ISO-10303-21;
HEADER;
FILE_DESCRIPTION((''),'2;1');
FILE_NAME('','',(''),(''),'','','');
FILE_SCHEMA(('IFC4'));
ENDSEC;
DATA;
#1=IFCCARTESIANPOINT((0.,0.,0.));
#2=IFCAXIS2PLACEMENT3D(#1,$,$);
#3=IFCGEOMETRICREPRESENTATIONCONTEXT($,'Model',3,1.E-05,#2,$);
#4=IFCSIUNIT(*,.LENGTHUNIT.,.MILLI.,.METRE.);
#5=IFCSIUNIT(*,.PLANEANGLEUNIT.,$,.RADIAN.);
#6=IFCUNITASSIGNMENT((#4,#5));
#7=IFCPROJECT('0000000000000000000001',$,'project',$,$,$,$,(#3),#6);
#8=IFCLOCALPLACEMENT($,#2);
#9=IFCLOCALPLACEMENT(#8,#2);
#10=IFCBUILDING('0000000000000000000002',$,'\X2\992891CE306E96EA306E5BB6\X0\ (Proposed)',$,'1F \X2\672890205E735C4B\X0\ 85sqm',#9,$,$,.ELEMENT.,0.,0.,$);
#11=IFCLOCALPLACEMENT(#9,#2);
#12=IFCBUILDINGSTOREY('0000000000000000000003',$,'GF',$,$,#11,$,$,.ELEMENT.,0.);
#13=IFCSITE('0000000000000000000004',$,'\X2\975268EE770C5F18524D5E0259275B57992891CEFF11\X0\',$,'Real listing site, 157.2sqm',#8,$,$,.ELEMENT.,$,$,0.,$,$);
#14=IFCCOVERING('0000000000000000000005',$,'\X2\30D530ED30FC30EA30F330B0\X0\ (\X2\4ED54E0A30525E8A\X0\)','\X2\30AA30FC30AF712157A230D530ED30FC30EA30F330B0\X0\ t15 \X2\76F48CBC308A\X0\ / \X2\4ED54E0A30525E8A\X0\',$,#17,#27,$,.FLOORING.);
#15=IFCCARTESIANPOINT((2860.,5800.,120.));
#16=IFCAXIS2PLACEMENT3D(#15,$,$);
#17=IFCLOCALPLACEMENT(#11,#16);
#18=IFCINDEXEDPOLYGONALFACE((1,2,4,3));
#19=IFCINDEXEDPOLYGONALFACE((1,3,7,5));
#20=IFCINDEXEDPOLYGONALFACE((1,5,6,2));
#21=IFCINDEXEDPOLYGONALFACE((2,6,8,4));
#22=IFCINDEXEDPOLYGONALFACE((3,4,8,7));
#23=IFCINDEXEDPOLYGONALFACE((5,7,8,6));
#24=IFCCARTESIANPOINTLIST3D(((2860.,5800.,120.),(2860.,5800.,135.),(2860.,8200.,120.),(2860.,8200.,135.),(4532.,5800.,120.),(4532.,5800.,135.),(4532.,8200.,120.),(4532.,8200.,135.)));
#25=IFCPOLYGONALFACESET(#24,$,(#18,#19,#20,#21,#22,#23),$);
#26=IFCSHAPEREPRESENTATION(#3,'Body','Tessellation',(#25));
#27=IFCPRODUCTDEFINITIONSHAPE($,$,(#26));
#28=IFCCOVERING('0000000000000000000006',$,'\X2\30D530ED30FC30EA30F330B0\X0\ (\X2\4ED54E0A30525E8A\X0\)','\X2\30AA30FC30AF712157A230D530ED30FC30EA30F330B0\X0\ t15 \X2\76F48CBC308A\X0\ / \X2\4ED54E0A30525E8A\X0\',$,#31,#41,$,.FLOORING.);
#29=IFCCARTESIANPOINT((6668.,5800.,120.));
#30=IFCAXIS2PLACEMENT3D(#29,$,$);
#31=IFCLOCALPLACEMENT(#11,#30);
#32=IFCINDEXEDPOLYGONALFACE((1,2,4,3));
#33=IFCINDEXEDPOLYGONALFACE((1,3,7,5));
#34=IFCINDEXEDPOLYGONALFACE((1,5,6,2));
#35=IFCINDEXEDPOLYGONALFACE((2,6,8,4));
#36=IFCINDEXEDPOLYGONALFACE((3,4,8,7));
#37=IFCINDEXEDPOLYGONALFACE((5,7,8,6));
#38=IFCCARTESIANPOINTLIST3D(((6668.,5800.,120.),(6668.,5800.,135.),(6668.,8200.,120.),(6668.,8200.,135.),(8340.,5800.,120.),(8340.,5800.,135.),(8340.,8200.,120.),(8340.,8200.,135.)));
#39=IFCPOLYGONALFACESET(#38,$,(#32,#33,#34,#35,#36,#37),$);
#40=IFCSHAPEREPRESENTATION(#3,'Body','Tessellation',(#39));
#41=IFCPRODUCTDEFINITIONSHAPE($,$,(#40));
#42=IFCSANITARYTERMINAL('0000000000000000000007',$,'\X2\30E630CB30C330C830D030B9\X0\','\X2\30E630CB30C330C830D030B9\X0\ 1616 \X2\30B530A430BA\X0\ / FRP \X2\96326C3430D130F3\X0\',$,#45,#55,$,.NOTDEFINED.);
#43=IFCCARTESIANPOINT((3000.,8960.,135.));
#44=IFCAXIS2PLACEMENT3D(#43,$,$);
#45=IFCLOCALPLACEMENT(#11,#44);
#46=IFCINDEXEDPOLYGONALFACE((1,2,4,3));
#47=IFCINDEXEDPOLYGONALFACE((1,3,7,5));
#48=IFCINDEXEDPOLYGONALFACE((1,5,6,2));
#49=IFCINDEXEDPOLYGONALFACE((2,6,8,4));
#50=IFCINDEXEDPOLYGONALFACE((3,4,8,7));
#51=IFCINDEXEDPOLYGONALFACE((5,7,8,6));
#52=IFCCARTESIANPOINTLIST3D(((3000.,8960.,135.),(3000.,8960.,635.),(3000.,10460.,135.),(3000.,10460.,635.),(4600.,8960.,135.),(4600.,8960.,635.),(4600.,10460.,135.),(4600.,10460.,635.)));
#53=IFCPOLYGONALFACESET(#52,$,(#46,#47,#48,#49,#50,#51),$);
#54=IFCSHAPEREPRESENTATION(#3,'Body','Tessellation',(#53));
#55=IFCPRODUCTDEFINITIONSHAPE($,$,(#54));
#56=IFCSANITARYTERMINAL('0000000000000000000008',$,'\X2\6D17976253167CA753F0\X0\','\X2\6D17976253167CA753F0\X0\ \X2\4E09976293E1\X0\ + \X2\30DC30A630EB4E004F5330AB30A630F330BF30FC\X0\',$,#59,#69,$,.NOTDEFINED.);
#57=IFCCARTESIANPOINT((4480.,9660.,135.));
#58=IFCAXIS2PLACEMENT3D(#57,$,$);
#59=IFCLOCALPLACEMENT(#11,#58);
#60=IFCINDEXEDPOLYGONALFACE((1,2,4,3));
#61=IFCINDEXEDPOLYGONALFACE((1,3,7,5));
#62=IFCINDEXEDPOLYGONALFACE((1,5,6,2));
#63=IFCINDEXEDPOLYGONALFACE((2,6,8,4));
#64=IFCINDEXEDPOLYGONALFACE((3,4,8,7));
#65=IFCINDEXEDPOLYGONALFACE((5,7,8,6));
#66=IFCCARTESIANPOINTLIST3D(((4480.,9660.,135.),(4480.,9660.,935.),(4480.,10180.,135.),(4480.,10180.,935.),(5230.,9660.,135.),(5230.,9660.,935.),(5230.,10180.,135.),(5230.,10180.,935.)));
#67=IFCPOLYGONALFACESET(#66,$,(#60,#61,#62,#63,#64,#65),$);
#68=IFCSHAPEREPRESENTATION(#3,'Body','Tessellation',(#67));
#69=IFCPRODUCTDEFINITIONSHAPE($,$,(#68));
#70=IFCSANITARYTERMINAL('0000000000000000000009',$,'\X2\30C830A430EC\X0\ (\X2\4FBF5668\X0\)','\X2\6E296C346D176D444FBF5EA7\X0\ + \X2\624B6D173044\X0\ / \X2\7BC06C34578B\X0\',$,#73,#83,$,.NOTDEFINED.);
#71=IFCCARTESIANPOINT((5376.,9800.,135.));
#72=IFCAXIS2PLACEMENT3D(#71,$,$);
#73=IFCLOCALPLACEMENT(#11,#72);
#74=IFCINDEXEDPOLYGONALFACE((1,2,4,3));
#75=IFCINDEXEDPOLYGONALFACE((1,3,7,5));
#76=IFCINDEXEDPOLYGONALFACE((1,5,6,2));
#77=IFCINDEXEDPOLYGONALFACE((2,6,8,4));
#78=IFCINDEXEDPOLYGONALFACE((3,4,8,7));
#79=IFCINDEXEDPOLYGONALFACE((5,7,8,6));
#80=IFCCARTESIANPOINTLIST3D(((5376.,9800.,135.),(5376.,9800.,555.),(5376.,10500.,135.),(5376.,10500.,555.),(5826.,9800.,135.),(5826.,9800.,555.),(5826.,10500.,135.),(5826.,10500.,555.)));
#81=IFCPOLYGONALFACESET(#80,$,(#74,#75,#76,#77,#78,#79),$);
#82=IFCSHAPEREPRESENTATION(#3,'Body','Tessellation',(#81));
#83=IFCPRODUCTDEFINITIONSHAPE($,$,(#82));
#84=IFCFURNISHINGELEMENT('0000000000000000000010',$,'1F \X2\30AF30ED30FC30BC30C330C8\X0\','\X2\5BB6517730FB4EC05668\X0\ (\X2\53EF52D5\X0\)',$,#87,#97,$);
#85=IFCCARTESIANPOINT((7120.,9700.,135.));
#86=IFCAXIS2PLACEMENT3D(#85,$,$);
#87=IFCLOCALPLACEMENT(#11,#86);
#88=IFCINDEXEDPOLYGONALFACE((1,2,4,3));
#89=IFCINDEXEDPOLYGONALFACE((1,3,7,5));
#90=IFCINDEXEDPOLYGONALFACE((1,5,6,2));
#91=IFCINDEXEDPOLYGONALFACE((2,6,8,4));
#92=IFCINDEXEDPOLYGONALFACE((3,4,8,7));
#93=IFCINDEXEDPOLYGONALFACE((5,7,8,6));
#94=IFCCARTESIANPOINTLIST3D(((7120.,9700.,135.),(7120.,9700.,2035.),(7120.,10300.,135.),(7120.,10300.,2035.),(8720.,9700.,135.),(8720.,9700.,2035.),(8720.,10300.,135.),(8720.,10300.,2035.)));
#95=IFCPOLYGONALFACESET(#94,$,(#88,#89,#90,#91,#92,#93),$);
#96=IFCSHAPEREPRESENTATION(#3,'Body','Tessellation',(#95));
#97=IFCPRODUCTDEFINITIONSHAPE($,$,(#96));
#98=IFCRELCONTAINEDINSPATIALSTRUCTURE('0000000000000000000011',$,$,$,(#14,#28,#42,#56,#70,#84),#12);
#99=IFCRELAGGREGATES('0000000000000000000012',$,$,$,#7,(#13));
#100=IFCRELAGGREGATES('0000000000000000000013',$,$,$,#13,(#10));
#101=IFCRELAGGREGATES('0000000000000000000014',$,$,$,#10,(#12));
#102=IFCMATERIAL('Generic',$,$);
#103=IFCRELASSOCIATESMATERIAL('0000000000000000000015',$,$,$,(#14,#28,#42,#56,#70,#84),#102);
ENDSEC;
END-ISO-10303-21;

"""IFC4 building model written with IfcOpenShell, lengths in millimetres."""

from ifc_helpers import new_model, si_unit, frame, frame_2d, origin, place, context, project, spatial, rectangle, extrude, material, element, save


model = new_model("IFC4")

# Units and contexts
model_context = context("Model", 3, precision=1e-05, world=origin())
ifc_project = project(units=[si_unit("LENGTHUNIT", "METRE", prefix="MILLI"), si_unit("PLANEANGLEUNIT", "RADIAN")], contexts=[model_context])

# Site, building, storey
site_placement = place(None, origin())
site = spatial("IfcSite", under=ifc_project, at=site_placement, Name="青森県弘前市大字館野１", ObjectType="Real listing site, 157.2sqm", CompositionType="ELEMENT", RefElevation=0.0)
building_placement = place(site_placement, origin())
building = spatial("IfcBuilding", under=site, at=building_placement, Name="館野の雪の家 (Proposed)", ObjectType="1F 木造平屋 85sqm", CompositionType="ELEMENT", ElevationOfRefHeight=0.0, ElevationOfTerrain=0.0)
storey_placement = place(building_placement, origin())
storey = spatial("IfcBuildingStorey", under=building, at=storey_placement, Name="GF", CompositionType="ELEMENT", Elevation=0.0)

# Coverings
ifc_material_1 = material(Name="Generic")
covering_1_placement = place(storey_placement, frame((2860.0, 5800.0, 120.0)))
element("IfcCovering", 1, at=covering_1_placement, inside=storey, material=ifc_material_1, Name="フローリング (仕上げ床)", Description="オーク無垢フローリング t15 直貼り / 仕上げ床", PredefinedType="FLOORING", context=model_context, shape_type="SweptSolid", body=[
    extrude(rectangle(XDim=1672.0, YDim=2400.0, at=frame_2d((836.0, 1200.0))), frame((2860.0, 5800.0, 120.0)), (0.0, 0.0, 1.0), 15.0),
])
covering_2_placement = place(storey_placement, frame((6668.0, 5800.0, 120.0)))
element("IfcCovering", 2, at=covering_2_placement, inside=storey, material=ifc_material_1, Name="フローリング (仕上げ床)", Description="オーク無垢フローリング t15 直貼り / 仕上げ床", PredefinedType="FLOORING", context=model_context, shape_type="SweptSolid", body=[
    extrude(rectangle(XDim=1672.0, YDim=2400.0, at=frame_2d((836.0, 1200.0))), frame((6668.0, 5800.0, 120.0)), (0.0, 0.0, 1.0), 15.0),
])

# Sanitary terminals
sanitary_terminal_1_placement = place(storey_placement, frame((3000.0, 8960.0, 135.0)))
element("IfcSanitaryTerminal", 3, at=sanitary_terminal_1_placement, inside=storey, material=ifc_material_1, Name="ユニットバス", Description="ユニットバス 1616 サイズ / FRP 防水パン", PredefinedType="NOTDEFINED", context=model_context, shape_type="SweptSolid", body=[
    extrude(rectangle(XDim=1600.0, YDim=1500.0, at=frame_2d((800.0, 750.0))), frame((3000.0, 8960.0, 135.0)), (0.0, 0.0, 1.0), 500.0),
])
sanitary_terminal_2_placement = place(storey_placement, frame((4480.0, 9660.0, 135.0)))
element("IfcSanitaryTerminal", 4, at=sanitary_terminal_2_placement, inside=storey, material=ifc_material_1, Name="洗面化粧台", Description="洗面化粧台 三面鏡 + ボウル一体カウンター", PredefinedType="NOTDEFINED", context=model_context, shape_type="SweptSolid", body=[
    extrude(rectangle(XDim=750.0, YDim=520.0, at=frame_2d((375.0, 260.0))), frame((4480.0, 9660.0, 135.0)), (0.0, 0.0, 1.0), 800.0),
])
sanitary_terminal_3_placement = place(storey_placement, frame((5376.0, 9800.0, 135.0)))
element("IfcSanitaryTerminal", 5, at=sanitary_terminal_3_placement, inside=storey, material=ifc_material_1, Name="トイレ (便器)", Description="温水洗浄便座 + 手洗い / 節水型", PredefinedType="NOTDEFINED", context=model_context, shape_type="SweptSolid", body=[
    extrude(rectangle(XDim=450.0, YDim=700.0, at=frame_2d((225.0, 350.0))), frame((5376.0, 9800.0, 135.0)), (0.0, 0.0, 1.0), 420.0),
])

# Furnishing element
furnishing_placement = place(storey_placement, frame((7120.0, 9700.0, 135.0)))
element("IfcFurnishingElement", 6, at=furnishing_placement, inside=storey, material=ifc_material_1, Name="1F クローゼット", Description="家具・什器 (可動)", context=model_context, shape_type="SweptSolid", body=[
    extrude(rectangle(XDim=1600.0, YDim=600.0, at=frame_2d((800.0, 300.0))), frame((7120.0, 9700.0, 135.0)), (0.0, 0.0, 1.0), 1900.0),
])

save(model, "model.ifc")
